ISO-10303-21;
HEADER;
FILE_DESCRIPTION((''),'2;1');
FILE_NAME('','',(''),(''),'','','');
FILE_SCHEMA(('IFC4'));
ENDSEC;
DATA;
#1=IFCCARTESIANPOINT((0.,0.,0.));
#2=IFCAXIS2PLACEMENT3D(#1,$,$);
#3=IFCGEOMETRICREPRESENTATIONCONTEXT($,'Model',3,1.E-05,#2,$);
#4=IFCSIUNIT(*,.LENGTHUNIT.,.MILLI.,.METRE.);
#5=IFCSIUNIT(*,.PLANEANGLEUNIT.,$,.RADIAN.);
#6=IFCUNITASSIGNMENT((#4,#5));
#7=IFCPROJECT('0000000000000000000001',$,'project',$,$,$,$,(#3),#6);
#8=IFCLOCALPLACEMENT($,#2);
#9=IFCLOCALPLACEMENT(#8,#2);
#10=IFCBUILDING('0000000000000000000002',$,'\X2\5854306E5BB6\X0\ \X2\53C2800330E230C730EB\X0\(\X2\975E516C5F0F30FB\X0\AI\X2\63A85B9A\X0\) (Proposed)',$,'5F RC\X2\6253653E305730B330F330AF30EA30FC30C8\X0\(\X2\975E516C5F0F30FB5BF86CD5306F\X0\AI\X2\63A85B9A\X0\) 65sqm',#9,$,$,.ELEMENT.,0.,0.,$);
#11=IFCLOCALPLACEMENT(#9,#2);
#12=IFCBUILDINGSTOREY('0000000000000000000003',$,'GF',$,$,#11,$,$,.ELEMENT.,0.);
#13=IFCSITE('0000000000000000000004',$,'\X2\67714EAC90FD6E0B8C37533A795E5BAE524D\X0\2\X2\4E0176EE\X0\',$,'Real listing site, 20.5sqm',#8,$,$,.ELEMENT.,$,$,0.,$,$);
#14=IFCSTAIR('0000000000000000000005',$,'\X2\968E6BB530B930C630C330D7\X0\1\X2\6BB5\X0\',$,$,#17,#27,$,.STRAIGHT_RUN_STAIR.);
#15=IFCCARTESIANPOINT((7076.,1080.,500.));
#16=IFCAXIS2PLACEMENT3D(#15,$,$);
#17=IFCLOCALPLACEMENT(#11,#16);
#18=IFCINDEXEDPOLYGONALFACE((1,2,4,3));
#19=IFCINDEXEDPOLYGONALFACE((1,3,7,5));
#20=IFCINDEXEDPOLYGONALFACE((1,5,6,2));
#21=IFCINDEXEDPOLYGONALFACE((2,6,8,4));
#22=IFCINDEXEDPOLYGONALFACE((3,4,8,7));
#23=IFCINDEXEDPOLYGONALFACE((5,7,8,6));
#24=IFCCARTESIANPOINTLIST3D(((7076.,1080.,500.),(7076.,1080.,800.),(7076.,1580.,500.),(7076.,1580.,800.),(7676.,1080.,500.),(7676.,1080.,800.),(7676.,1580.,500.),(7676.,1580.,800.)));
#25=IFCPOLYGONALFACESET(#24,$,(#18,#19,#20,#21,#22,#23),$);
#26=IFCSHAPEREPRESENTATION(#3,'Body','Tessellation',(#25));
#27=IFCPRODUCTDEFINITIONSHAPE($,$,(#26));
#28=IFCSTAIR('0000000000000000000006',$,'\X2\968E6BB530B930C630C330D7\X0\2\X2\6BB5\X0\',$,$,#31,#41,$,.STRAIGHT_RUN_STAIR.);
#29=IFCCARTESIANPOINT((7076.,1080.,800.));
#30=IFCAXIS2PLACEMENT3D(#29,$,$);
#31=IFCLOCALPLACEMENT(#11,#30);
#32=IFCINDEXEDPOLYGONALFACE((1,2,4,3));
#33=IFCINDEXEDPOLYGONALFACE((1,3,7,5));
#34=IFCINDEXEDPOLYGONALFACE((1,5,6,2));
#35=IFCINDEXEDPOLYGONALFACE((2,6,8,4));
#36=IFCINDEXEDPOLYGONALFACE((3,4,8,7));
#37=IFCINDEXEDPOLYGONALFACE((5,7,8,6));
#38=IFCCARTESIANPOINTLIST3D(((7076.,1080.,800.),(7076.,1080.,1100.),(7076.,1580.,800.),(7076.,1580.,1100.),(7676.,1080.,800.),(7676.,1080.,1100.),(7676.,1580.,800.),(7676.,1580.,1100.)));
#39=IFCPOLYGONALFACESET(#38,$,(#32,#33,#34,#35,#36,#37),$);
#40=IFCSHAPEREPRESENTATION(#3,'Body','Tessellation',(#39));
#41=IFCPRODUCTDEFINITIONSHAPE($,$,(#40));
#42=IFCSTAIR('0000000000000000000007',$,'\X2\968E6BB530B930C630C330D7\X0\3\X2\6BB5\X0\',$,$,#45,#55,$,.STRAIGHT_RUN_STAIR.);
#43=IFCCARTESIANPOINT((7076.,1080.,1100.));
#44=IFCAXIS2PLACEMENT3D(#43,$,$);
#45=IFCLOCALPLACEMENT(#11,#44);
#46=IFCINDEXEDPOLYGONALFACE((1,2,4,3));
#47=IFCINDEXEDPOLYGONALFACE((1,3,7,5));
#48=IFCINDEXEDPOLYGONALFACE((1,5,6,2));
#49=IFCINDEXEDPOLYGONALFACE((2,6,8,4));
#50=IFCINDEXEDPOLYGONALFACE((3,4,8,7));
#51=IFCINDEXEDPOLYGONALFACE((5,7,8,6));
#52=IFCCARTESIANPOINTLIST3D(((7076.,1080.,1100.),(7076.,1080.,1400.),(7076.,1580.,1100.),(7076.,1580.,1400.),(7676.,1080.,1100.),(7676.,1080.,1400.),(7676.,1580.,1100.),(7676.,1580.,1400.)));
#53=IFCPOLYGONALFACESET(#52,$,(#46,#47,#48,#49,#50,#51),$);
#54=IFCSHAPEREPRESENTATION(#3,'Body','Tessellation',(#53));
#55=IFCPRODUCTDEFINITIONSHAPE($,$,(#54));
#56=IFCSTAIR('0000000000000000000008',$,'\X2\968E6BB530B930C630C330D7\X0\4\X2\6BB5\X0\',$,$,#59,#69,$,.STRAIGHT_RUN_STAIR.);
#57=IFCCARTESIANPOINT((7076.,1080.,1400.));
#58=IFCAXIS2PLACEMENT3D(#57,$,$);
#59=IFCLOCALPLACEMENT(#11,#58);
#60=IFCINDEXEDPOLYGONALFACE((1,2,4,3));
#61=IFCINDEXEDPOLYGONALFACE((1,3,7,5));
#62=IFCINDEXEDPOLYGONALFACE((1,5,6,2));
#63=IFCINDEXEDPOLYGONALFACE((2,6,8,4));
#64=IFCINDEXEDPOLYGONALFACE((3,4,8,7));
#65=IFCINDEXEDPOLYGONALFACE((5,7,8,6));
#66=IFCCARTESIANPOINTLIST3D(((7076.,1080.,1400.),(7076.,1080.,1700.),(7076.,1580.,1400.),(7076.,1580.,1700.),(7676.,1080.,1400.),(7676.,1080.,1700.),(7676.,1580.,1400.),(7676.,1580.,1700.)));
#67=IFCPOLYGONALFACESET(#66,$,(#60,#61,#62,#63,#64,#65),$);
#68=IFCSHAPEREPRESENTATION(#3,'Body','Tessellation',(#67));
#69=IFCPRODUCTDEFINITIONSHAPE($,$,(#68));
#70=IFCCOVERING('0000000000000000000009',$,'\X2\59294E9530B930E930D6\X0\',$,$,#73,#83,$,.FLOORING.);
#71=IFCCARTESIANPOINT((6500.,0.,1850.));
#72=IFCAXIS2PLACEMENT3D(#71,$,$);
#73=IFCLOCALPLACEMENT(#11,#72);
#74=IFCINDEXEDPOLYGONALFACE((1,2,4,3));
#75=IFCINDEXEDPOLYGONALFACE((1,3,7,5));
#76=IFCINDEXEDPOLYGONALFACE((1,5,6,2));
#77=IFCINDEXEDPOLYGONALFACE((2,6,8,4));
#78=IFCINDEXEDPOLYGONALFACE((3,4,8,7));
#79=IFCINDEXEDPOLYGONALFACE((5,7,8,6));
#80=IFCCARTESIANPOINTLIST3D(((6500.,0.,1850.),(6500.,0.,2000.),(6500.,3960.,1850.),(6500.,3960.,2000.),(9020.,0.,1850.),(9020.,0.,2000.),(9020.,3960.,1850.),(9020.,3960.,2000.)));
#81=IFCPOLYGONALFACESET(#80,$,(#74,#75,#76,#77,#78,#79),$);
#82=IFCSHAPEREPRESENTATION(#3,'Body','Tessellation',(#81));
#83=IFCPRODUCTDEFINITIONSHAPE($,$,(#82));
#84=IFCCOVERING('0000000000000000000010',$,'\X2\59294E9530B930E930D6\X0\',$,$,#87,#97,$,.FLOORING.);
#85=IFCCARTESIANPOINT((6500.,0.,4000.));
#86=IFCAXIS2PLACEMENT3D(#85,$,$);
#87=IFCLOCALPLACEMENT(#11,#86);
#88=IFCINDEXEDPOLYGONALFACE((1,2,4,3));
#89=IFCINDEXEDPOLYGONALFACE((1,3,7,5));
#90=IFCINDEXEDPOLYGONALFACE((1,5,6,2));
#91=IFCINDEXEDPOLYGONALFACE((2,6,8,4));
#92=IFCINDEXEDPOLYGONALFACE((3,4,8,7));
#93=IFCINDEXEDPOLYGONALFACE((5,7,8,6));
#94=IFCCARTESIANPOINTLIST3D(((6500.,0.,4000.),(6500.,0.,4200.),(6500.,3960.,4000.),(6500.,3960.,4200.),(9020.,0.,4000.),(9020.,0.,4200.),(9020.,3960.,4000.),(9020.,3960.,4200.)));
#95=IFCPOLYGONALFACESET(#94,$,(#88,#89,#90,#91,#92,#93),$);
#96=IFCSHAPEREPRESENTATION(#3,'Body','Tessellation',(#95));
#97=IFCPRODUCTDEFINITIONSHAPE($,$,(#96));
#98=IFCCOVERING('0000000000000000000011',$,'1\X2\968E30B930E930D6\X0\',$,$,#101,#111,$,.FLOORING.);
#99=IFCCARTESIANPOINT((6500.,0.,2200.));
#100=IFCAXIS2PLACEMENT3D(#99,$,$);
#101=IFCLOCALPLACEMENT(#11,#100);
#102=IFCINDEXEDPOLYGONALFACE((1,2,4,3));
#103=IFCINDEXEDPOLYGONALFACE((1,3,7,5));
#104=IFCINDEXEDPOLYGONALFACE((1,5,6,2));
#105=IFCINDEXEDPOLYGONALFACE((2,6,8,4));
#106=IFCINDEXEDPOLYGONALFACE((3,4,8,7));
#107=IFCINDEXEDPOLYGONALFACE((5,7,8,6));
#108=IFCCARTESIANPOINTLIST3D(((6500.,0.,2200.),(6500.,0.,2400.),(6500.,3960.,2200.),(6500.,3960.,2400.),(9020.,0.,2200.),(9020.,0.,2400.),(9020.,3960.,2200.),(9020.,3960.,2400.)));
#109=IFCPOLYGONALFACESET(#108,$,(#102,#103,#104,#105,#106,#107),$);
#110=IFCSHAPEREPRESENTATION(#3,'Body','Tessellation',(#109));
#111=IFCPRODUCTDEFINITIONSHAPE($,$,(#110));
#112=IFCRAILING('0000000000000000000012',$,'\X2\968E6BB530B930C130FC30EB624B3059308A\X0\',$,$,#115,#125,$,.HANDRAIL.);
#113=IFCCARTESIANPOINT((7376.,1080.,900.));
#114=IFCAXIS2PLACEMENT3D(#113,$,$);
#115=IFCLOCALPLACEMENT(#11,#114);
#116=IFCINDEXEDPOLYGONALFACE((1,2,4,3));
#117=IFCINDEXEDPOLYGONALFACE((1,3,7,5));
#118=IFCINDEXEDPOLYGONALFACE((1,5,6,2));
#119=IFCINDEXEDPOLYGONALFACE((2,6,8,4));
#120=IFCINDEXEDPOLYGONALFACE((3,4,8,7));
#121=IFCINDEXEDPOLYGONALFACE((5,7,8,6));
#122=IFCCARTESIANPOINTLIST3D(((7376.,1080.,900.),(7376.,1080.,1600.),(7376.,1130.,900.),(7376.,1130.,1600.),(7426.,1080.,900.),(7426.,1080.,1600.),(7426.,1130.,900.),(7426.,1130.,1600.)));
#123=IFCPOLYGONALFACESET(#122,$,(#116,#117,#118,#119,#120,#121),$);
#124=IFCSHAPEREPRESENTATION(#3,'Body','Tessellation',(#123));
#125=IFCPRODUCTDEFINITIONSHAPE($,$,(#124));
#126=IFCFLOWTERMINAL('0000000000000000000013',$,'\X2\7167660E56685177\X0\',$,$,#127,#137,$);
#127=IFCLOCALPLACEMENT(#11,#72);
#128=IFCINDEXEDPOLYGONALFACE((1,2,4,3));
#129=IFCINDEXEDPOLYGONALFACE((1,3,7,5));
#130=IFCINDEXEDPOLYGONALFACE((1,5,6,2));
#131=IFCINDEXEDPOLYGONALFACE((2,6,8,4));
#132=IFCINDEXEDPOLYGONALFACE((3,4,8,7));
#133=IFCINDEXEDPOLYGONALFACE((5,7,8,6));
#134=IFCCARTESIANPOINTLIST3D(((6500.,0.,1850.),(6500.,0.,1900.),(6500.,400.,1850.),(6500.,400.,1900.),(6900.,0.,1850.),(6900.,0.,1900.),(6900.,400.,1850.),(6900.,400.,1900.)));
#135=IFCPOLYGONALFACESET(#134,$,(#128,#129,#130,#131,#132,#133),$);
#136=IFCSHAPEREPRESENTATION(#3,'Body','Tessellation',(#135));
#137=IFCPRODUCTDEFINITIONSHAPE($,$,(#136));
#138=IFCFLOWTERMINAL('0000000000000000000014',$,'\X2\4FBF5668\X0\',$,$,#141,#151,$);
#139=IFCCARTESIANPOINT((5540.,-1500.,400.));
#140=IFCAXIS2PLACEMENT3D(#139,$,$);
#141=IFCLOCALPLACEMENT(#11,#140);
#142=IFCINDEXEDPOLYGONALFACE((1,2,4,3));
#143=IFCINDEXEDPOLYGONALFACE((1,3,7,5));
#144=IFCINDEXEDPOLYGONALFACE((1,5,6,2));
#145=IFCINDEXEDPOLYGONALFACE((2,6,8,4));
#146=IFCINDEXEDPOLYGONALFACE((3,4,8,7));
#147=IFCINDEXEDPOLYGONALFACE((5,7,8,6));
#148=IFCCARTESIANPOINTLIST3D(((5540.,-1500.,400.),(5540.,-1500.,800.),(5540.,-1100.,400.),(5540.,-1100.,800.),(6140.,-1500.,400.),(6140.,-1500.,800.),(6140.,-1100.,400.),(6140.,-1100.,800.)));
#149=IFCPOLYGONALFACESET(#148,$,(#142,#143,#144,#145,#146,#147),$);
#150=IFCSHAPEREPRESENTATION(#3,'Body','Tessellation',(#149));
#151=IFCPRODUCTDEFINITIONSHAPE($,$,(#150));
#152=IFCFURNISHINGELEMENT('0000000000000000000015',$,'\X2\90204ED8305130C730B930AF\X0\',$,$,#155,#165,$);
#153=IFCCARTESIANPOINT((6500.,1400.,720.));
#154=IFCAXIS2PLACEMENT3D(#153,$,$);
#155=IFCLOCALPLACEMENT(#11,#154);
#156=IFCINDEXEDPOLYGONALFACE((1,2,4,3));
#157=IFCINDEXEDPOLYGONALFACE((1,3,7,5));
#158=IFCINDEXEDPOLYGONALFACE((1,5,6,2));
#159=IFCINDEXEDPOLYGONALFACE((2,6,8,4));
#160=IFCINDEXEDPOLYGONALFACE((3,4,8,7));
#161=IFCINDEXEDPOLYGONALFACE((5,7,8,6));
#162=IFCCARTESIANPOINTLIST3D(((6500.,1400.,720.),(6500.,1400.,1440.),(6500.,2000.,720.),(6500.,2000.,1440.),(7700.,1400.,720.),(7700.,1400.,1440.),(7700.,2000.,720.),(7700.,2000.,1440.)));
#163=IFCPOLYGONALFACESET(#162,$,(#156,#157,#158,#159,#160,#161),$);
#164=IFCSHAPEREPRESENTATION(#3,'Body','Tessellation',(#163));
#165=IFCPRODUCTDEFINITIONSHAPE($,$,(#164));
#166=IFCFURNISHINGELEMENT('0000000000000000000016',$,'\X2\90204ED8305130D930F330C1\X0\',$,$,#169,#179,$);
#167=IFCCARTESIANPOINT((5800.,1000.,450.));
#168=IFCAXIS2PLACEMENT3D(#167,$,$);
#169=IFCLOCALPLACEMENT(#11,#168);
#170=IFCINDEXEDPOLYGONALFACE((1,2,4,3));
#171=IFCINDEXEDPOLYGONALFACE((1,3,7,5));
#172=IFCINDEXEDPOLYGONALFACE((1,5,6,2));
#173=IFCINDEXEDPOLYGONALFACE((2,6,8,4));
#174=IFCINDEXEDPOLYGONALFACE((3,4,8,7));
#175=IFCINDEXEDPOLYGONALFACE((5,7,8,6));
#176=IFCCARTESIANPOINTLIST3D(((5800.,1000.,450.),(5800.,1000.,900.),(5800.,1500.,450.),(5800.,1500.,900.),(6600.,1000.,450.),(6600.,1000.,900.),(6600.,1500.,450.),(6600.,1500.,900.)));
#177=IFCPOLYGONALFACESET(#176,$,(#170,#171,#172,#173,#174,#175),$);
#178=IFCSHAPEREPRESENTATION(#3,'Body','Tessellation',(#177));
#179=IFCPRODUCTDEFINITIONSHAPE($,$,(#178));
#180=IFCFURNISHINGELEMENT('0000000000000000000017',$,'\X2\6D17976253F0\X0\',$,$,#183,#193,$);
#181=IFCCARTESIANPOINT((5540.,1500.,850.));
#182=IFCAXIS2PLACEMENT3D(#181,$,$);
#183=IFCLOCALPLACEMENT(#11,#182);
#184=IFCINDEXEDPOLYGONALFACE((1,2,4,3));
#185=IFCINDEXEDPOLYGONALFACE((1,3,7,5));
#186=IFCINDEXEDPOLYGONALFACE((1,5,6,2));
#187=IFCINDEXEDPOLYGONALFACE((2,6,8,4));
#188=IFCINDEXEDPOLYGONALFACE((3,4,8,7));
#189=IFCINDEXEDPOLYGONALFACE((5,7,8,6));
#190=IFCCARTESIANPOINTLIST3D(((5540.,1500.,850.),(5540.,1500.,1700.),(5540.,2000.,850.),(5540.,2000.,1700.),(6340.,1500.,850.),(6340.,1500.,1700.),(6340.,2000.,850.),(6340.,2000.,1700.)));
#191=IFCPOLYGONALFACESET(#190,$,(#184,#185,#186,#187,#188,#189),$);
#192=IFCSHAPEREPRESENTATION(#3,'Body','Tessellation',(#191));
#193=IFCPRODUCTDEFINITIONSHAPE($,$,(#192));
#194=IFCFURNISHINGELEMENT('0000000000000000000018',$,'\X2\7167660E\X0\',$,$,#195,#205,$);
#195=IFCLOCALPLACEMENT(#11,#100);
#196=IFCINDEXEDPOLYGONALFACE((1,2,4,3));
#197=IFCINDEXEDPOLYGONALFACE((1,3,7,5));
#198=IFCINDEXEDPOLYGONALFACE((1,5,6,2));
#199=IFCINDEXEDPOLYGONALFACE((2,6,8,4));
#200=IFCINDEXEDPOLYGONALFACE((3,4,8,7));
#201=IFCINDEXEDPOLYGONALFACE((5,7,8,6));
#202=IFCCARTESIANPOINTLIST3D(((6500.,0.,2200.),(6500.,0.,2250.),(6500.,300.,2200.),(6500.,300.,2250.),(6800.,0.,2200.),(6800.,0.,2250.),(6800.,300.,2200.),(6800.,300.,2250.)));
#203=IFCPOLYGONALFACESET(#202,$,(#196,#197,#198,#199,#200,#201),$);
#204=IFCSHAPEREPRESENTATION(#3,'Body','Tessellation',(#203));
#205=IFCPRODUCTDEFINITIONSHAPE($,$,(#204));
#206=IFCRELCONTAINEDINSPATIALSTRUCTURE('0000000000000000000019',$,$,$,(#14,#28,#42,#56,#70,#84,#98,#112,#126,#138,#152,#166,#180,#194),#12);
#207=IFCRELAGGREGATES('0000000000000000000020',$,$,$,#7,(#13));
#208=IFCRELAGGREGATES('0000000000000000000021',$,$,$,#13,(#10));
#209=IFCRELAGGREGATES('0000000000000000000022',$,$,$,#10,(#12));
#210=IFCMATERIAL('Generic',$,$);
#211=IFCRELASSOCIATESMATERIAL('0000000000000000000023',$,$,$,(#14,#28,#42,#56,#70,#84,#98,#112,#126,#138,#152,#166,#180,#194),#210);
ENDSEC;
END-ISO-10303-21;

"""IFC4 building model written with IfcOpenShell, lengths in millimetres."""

from ifc_helpers import new_model, si_unit, frame, frame_2d, origin, place, context, project, spatial, rectangle, extrude, material, element, save


model = new_model("IFC4")

# Units and contexts
model_context = context("Model", 3, precision=1e-05, world=origin())
ifc_project = project(units=[si_unit("LENGTHUNIT", "METRE", prefix="MILLI"), si_unit("PLANEANGLEUNIT", "RADIAN")], contexts=[model_context])

# Site, building, storey
site_placement = place(None, origin())
site = spatial("IfcSite", under=ifc_project, at=site_placement, Name="東京都渋谷区神宮前2丁目", ObjectType="Real listing site, 20.5sqm", CompositionType="ELEMENT", RefElevation=0.0)
building_placement = place(site_placement, origin())
building = spatial("IfcBuilding", under=site, at=building_placement, Name="塔の家 参考モデル(非公式・AI推定) (Proposed)", ObjectType="5F RC打放しコンクリート(非公式・寸法はAI推定) 65sqm", CompositionType="ELEMENT", ElevationOfRefHeight=0.0, ElevationOfTerrain=0.0)
storey_placement = place(building_placement, origin())
storey = spatial("IfcBuildingStorey", under=building, at=storey_placement, Name="GF", CompositionType="ELEMENT", Elevation=0.0)

# Shared definitions
ifc_material = material(Name="Generic")

# Stairs
stair_1_placement = place(storey_placement, frame((7076.0, 1080.0, 500.0)))
element("IfcStair", 1, at=stair_1_placement, inside=storey, material=ifc_material, Name="階段ステップ1段", PredefinedType="STRAIGHT_RUN_STAIR", context=model_context, shape_type="SweptSolid", body=[
    extrude(rectangle(XDim=600.0, YDim=500.0, at=frame_2d((300.0, 250.0))), frame((7076.0, 1080.0, 500.0)), (0.0, 0.0, 1.0), 300.0),
])
stair_2_placement = place(storey_placement, frame((7076.0, 1080.0, 800.0)))
element("IfcStair", 2, at=stair_2_placement, inside=storey, material=ifc_material, Name="階段ステップ2段", PredefinedType="STRAIGHT_RUN_STAIR", context=model_context, shape_type="SweptSolid", body=[
    extrude(rectangle(XDim=600.0, YDim=500.0, at=frame_2d((300.0, 250.0))), frame((7076.0, 1080.0, 800.0)), (0.0, 0.0, 1.0), 300.0),
])
stair_3_placement = place(storey_placement, frame((7076.0, 1080.0, 1100.0)))
element("IfcStair", 3, at=stair_3_placement, inside=storey, material=ifc_material, Name="階段ステップ3段", PredefinedType="STRAIGHT_RUN_STAIR", context=model_context, shape_type="SweptSolid", body=[
    extrude(rectangle(XDim=600.0, YDim=500.0, at=frame_2d((300.0, 250.0))), frame((7076.0, 1080.0, 1100.0)), (0.0, 0.0, 1.0), 300.0),
])
stair_4_placement = place(storey_placement, frame((7076.0, 1080.0, 1400.0)))
element("IfcStair", 4, at=stair_4_placement, inside=storey, material=ifc_material, Name="階段ステップ4段", PredefinedType="STRAIGHT_RUN_STAIR", context=model_context, shape_type="SweptSolid", body=[
    extrude(rectangle(XDim=600.0, YDim=500.0, at=frame_2d((300.0, 250.0))), frame((7076.0, 1080.0, 1400.0)), (0.0, 0.0, 1.0), 300.0),
])

# Coverings
covering_1_placement = place(storey_placement, frame((6500.0, 0.0, 1850.0)))
element("IfcCovering", 5, at=covering_1_placement, inside=storey, material=ifc_material, Name="天井スラブ", PredefinedType="FLOORING", context=model_context, shape_type="SweptSolid", body=[
    extrude(rectangle(XDim=2520.0, YDim=3960.0, at=frame_2d((1260.0, 1980.0))), frame((6500.0, 0.0, 1850.0)), (0.0, 0.0, 1.0), 150.0),
])
covering_2_placement = place(storey_placement, frame((6500.0, 0.0, 4000.0)))
element("IfcCovering", 6, at=covering_2_placement, inside=storey, material=ifc_material, Name="天井スラブ", PredefinedType="FLOORING", context=model_context, shape_type="SweptSolid", body=[
    extrude(rectangle(XDim=2520.0, YDim=3960.0, at=frame_2d((1260.0, 1980.0))), frame((6500.0, 0.0, 4000.0)), (0.0, 0.0, 1.0), 200.0),
])
covering_3_placement = place(storey_placement, frame((6500.0, 0.0, 2200.0)))
element("IfcCovering", 7, at=covering_3_placement, inside=storey, material=ifc_material, Name="1階スラブ", PredefinedType="FLOORING", context=model_context, shape_type="SweptSolid", body=[
    extrude(rectangle(XDim=2520.0, YDim=3960.0, at=frame_2d((1260.0, 1980.0))), frame((6500.0, 0.0, 2200.0)), (0.0, 0.0, 1.0), 200.0),
])

# Railing
railing_placement = place(storey_placement, frame((7376.0, 1080.0, 900.0)))
element("IfcRailing", 8, at=railing_placement, inside=storey, material=ifc_material, Name="階段スチール手すり", PredefinedType="HANDRAIL", context=model_context, shape_type="SweptSolid", body=[
    extrude(rectangle(XDim=50.0, YDim=50.0, at=frame_2d((25.0, 25.0))), frame((7376.0, 1080.0, 900.0)), (0.0, 0.0, 1.0), 700.0),
])

# Flow terminals
flow_terminal_1_placement = place(storey_placement, frame((6500.0, 0.0, 1850.0)))
element("IfcFlowTerminal", 9, at=flow_terminal_1_placement, inside=storey, material=ifc_material, Name="照明器具", context=model_context, shape_type="SweptSolid", body=[
    extrude(rectangle(XDim=400.0, YDim=400.0, at=frame_2d((200.0, 200.0))), frame((6500.0, 0.0, 1850.0)), (0.0, 0.0, 1.0), 50.0),
])
flow_terminal_2_placement = place(storey_placement, frame((5540.0, -1500.0, 400.0)))
element("IfcFlowTerminal", 10, at=flow_terminal_2_placement, inside=storey, material=ifc_material, Name="便器", context=model_context, shape_type="SweptSolid", body=[
    extrude(rectangle(XDim=600.0, YDim=400.0, at=frame_2d((300.0, 200.0))), frame((5540.0, -1500.0, 400.0)), (0.0, 0.0, 1.0), 400.0),
])

# Furnishing elements
furnishing_1_placement = place(storey_placement, frame((6500.0, 1400.0, 720.0)))
element("IfcFurnishingElement", 11, at=furnishing_1_placement, inside=storey, material=ifc_material, Name="造付けデスク", context=model_context, shape_type="SweptSolid", body=[
    extrude(rectangle(XDim=1200.0, YDim=600.0, at=frame_2d((600.0, 300.0))), frame((6500.0, 1400.0, 720.0)), (0.0, 0.0, 1.0), 720.0),
])
furnishing_2_placement = place(storey_placement, frame((5800.0, 1000.0, 450.0)))
element("IfcFurnishingElement", 12, at=furnishing_2_placement, inside=storey, material=ifc_material, Name="造付けベンチ", context=model_context, shape_type="SweptSolid", body=[
    extrude(rectangle(XDim=800.0, YDim=500.0, at=frame_2d((400.0, 250.0))), frame((5800.0, 1000.0, 450.0)), (0.0, 0.0, 1.0), 450.0),
])
furnishing_3_placement = place(storey_placement, frame((5540.0, 1500.0, 850.0)))
element("IfcFurnishingElement", 13, at=furnishing_3_placement, inside=storey, material=ifc_material, Name="洗面台", context=model_context, shape_type="SweptSolid", body=[
    extrude(rectangle(XDim=800.0, YDim=500.0, at=frame_2d((400.0, 250.0))), frame((5540.0, 1500.0, 850.0)), (0.0, 0.0, 1.0), 850.0),
])
furnishing_4_placement = place(storey_placement, frame((6500.0, 0.0, 2200.0)))
element("IfcFurnishingElement", 14, at=furnishing_4_placement, inside=storey, material=ifc_material, Name="照明", context=model_context, shape_type="SweptSolid", body=[
    extrude(rectangle(XDim=300.0, YDim=300.0, at=frame_2d((150.0, 150.0))), frame((6500.0, 0.0, 2200.0)), (0.0, 0.0, 1.0), 50.0),
])

save(model, "model.ifc")
